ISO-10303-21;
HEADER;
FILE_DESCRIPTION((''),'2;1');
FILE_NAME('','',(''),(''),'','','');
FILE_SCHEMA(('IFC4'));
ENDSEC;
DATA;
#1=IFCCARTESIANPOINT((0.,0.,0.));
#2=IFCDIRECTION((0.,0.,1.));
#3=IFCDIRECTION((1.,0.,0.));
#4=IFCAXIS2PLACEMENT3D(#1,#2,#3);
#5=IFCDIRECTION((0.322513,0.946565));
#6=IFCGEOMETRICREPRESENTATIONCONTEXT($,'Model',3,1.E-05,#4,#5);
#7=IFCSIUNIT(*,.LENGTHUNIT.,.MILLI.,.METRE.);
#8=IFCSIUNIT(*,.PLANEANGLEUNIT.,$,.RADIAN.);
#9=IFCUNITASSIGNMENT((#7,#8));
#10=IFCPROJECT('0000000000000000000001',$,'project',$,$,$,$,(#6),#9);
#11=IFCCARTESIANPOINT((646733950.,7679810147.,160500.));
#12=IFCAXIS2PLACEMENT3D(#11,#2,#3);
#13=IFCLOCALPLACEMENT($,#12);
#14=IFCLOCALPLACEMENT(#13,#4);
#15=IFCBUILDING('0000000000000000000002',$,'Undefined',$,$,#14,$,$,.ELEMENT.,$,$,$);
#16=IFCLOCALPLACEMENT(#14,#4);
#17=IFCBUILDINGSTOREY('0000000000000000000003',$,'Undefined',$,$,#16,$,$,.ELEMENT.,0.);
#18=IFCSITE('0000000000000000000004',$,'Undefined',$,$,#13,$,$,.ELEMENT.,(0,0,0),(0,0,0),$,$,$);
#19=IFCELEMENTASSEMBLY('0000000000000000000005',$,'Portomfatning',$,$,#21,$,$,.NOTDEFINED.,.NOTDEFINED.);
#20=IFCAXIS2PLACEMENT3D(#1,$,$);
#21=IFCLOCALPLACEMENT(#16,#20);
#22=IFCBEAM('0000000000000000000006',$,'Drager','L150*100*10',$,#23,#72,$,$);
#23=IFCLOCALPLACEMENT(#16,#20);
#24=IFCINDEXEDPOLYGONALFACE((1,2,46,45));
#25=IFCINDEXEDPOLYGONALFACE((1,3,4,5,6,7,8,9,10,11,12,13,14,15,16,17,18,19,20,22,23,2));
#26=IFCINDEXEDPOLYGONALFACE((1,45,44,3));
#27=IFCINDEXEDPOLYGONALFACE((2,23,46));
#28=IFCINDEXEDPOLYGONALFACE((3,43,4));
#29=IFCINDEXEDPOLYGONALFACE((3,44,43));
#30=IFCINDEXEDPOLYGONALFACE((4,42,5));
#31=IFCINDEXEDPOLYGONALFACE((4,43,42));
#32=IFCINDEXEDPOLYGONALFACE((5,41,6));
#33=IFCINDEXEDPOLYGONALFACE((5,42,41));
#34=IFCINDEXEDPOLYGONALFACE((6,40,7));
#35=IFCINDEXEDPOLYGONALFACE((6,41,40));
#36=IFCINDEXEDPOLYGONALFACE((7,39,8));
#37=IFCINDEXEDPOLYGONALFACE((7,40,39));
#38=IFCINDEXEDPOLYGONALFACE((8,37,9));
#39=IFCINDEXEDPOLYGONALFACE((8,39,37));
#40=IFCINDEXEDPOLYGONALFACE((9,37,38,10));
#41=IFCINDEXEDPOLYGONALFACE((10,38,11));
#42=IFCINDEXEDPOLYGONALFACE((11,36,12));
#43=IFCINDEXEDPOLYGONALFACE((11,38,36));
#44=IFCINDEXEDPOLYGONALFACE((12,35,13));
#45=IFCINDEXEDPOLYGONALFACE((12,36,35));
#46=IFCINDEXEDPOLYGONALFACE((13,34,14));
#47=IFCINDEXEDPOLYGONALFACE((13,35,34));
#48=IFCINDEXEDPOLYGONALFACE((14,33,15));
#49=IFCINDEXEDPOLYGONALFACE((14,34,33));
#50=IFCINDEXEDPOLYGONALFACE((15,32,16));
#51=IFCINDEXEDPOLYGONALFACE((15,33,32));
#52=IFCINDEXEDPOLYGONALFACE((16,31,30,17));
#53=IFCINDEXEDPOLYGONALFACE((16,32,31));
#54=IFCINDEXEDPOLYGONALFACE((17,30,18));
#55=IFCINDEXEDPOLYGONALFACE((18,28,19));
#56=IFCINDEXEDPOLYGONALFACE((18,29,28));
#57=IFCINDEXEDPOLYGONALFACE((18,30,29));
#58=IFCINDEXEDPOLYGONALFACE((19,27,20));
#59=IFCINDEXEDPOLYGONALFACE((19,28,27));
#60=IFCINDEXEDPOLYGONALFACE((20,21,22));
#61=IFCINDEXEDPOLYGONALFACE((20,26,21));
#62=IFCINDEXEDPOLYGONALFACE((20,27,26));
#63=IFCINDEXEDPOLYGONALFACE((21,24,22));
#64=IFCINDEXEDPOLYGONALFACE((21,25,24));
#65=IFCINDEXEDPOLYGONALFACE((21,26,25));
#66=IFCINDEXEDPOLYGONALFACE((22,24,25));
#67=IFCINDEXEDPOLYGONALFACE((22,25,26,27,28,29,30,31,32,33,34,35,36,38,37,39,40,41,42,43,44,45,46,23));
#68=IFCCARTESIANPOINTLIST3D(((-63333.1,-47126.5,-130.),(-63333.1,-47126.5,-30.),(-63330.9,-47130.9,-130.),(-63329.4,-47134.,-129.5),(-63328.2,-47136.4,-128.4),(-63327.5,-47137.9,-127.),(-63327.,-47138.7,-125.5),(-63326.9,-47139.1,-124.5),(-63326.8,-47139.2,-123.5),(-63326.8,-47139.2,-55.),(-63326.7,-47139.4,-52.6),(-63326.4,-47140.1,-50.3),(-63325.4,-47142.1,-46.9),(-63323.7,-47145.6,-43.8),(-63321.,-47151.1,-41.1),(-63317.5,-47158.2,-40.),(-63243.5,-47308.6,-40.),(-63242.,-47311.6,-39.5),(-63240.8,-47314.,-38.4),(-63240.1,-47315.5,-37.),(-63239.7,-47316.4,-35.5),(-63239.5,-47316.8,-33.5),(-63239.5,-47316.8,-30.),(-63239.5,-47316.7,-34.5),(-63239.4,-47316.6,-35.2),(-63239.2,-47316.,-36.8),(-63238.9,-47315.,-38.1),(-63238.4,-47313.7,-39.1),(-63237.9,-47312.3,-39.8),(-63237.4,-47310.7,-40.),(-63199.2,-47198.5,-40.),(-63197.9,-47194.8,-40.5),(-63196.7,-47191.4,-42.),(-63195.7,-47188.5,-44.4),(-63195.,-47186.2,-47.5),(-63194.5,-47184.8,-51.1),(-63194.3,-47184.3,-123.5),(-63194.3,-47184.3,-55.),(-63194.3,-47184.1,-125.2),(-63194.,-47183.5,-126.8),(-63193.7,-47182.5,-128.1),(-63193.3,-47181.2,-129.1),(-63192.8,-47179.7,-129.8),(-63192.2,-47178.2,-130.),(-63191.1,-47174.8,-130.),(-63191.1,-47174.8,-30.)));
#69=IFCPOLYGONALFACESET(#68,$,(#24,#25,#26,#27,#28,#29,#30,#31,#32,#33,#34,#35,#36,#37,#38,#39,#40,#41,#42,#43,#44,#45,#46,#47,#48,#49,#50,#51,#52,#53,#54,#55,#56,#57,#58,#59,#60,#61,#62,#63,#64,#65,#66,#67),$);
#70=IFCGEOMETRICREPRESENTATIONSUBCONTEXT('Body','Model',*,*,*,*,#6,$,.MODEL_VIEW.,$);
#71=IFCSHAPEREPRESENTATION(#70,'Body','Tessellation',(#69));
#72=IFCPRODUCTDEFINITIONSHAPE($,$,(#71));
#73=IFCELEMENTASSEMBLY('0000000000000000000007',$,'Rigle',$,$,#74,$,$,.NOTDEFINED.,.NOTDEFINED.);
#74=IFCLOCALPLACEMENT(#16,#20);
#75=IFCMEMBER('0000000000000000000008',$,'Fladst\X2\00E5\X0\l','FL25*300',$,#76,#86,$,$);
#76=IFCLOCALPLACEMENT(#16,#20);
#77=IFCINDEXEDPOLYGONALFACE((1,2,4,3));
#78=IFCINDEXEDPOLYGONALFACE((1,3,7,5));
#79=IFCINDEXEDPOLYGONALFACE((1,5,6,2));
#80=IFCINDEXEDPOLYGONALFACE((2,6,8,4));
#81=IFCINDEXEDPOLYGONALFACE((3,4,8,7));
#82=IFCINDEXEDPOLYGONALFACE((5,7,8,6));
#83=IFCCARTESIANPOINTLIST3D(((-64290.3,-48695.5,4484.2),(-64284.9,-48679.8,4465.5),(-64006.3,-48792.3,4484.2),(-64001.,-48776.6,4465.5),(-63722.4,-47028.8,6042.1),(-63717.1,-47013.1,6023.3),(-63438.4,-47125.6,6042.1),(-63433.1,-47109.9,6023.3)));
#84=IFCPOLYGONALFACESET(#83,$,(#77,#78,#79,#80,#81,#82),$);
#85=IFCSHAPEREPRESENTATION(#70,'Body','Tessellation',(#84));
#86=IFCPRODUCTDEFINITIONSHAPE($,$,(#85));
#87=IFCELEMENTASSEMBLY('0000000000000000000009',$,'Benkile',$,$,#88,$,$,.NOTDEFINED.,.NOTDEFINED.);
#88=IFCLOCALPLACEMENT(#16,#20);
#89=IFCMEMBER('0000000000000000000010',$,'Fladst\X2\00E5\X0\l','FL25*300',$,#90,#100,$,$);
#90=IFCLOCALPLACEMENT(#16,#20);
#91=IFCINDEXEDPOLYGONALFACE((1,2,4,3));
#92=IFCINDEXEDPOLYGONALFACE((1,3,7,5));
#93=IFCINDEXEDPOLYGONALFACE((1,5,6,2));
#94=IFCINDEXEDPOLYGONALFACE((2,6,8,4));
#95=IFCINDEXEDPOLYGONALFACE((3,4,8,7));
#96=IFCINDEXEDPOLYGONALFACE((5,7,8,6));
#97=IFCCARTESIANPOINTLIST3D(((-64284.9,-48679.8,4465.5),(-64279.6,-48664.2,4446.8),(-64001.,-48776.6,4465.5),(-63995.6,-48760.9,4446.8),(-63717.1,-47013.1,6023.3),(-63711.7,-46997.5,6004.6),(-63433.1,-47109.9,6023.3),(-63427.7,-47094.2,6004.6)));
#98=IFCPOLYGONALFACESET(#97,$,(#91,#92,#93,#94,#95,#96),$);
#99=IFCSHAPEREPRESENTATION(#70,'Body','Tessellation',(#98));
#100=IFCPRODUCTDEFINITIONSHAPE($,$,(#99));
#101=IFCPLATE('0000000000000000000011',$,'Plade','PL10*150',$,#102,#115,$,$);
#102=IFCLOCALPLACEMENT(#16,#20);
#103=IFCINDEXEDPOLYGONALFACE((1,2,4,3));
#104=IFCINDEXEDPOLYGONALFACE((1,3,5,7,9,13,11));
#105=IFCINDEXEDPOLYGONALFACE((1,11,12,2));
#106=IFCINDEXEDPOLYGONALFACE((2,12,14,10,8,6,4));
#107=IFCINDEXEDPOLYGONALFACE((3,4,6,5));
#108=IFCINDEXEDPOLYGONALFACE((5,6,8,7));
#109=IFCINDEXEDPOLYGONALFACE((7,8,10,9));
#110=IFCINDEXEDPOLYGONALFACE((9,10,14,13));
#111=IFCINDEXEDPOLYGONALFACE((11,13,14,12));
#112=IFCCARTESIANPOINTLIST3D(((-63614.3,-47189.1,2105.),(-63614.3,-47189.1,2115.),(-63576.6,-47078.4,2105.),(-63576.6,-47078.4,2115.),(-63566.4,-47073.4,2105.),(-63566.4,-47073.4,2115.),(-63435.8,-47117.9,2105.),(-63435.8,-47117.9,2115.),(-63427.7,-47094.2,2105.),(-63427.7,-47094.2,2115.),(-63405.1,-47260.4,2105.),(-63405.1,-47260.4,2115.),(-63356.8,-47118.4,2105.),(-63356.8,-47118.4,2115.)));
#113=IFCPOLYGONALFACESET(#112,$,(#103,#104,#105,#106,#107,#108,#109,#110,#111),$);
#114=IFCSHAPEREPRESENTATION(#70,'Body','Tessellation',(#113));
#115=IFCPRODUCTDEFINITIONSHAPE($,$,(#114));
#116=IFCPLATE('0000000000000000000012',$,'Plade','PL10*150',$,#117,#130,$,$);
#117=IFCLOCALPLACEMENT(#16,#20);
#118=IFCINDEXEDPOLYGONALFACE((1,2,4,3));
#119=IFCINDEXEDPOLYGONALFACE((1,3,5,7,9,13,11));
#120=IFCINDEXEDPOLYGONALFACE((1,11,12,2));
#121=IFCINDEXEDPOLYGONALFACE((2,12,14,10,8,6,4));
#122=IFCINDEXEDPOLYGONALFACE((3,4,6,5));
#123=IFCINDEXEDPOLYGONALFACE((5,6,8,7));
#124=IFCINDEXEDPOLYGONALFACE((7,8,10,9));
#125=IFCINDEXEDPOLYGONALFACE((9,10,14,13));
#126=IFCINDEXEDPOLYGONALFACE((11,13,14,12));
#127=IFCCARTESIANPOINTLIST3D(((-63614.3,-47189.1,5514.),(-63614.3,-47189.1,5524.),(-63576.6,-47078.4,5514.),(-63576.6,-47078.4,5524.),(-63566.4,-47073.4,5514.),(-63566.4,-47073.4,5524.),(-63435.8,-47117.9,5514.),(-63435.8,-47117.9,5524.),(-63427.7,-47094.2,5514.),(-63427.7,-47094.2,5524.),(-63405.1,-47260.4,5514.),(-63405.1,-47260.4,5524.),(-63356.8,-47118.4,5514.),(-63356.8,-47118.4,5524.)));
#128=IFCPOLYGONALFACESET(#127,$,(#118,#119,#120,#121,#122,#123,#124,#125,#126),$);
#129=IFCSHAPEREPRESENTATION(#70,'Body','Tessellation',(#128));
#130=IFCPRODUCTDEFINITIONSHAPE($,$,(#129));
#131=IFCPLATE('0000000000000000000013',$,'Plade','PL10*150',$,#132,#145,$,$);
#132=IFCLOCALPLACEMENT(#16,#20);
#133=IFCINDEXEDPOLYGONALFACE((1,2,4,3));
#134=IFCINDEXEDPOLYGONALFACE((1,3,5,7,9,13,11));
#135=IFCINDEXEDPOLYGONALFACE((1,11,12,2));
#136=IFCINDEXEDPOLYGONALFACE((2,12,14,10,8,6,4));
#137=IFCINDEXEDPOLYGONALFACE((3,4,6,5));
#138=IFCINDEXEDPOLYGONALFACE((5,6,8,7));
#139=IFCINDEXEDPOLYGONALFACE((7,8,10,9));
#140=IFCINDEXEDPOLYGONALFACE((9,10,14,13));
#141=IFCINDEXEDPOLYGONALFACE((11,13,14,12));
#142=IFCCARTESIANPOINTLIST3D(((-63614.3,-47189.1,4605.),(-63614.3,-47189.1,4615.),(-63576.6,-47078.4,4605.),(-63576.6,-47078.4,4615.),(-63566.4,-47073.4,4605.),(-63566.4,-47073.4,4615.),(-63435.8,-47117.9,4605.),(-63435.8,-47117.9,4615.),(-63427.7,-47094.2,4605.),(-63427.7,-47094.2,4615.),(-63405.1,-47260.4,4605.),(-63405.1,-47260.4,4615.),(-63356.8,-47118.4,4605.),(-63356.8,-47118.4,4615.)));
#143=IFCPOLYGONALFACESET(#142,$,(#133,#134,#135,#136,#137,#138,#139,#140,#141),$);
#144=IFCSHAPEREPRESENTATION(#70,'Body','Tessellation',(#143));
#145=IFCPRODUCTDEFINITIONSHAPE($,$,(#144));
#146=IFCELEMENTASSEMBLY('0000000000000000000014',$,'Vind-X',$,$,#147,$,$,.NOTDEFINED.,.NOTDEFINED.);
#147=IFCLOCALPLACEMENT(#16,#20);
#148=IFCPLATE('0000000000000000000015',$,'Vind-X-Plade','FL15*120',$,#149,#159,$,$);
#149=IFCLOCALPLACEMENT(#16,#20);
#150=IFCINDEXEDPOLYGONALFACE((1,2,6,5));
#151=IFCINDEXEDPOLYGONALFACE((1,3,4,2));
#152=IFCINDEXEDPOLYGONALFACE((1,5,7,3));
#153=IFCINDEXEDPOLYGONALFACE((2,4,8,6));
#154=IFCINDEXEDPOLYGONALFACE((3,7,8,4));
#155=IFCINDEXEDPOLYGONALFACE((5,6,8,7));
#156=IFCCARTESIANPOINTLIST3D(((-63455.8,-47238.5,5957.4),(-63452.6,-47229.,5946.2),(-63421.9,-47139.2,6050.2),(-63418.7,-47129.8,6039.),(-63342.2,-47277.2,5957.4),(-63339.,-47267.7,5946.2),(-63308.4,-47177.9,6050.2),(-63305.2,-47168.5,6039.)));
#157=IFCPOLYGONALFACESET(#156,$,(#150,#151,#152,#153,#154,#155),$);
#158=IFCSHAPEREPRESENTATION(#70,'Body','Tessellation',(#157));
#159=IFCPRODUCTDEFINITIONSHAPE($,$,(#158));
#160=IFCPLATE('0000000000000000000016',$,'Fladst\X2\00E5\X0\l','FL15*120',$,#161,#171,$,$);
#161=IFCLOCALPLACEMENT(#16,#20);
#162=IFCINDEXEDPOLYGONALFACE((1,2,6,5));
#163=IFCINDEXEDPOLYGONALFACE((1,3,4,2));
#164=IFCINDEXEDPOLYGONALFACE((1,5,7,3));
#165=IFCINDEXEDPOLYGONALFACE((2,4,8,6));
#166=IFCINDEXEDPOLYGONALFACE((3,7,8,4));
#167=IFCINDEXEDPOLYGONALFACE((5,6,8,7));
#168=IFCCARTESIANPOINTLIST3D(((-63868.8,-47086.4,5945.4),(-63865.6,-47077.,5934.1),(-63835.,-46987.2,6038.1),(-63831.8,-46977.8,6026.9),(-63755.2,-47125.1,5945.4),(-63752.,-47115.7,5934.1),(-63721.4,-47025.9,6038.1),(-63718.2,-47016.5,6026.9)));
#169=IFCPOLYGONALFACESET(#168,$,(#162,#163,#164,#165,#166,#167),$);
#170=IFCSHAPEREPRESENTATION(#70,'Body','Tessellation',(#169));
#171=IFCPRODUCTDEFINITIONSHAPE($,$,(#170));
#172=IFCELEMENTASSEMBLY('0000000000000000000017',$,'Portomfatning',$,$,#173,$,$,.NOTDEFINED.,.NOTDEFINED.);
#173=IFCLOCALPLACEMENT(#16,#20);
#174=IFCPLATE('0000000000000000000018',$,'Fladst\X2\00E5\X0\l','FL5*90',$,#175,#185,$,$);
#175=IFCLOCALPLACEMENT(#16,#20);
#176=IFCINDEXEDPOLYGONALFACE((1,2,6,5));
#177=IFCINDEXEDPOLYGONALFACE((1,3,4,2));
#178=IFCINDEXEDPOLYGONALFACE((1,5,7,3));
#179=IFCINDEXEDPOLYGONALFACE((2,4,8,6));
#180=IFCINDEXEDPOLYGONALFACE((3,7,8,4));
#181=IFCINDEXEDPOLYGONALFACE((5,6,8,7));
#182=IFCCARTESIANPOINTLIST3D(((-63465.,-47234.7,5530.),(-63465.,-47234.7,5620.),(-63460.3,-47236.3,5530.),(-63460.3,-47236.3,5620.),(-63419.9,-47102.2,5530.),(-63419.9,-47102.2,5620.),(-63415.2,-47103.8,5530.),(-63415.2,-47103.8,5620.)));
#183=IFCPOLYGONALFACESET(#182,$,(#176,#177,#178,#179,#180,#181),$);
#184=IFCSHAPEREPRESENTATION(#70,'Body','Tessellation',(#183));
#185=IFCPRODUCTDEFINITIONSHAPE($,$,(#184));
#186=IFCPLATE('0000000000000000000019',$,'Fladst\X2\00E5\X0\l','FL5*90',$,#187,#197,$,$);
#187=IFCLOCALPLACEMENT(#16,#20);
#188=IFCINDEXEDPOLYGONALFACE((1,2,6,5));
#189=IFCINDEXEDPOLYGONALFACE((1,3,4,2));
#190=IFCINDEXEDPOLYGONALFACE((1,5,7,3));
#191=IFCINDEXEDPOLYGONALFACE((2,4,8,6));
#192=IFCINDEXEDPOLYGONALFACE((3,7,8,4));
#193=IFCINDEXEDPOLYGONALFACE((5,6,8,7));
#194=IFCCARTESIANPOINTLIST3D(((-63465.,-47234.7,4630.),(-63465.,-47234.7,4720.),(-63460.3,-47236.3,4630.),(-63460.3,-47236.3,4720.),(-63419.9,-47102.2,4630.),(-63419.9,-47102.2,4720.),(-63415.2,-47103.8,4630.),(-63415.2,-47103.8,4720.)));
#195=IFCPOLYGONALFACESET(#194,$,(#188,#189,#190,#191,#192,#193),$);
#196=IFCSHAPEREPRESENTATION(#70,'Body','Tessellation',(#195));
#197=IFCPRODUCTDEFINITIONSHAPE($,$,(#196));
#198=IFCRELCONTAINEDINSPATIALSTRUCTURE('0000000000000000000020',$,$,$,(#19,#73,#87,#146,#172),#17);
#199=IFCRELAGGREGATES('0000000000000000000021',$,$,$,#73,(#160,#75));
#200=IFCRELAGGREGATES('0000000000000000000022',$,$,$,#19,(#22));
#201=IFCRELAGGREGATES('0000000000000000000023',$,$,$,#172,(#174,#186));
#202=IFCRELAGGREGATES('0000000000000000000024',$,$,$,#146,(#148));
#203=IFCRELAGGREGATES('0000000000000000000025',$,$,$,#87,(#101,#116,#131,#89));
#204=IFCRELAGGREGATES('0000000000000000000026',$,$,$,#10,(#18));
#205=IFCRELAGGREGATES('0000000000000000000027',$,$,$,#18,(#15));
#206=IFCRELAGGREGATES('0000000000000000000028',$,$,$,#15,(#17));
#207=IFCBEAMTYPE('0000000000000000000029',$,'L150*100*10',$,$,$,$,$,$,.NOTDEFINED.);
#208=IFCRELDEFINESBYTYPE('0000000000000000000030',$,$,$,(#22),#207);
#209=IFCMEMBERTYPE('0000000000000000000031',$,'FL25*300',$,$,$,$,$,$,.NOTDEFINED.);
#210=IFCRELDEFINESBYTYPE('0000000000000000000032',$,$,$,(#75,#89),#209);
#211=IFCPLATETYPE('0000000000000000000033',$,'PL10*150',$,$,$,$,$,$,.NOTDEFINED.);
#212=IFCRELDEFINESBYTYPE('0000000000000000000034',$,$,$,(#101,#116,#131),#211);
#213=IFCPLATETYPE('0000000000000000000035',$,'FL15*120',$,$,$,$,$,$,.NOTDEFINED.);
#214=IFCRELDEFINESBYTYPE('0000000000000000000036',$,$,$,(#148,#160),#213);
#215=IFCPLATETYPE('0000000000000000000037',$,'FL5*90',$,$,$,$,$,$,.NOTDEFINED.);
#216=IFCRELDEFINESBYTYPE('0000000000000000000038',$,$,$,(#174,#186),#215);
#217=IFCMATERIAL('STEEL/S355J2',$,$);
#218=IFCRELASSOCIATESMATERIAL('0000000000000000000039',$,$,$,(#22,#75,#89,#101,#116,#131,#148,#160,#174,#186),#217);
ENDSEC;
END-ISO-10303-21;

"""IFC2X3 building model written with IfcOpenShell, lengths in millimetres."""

from ifc_helpers import new_model, si_unit, direction, frame, origin_with_axes, origin_2d_with_axis, place, context, subcontext, project, spatial, polyline, rectangle, l_section, outline, extrude, boolean, clip, halfspace, material, type_object, element, aggregate, save


model = new_model("IFC2X3")

# Units and contexts
model_context = context("Model", 3, precision=1e-05, world=origin_with_axes(), true_north=direction((0.322513, 0.946565)))
body_context = subcontext(model_context, "Body", "Model", "MODEL_VIEW")
ifc_project = project(units=[si_unit("LENGTHUNIT", "METRE", prefix="MILLI"), si_unit("PLANEANGLEUNIT", "RADIAN")], contexts=[model_context])

# Site, building, storey
site_placement = place(None, frame((646733950.0, 7679810147.0, 160500.0), z_axis=(0.0, 0.0, 1.0), x_axis=(1.0, 0.0, 0.0)))
site = spatial("IfcSite", under=ifc_project, at=site_placement, Name="Undefined", CompositionType="ELEMENT", RefLatitude=(0, 0, 0), RefLongitude=(0, 0, 0))
building_placement = place(site_placement, origin_with_axes())
building = spatial("IfcBuilding", under=site, at=building_placement, Name="Undefined", CompositionType="ELEMENT")
storey_placement = place(building_placement, origin_with_axes())
storey = spatial("IfcBuildingStorey", under=building, at=storey_placement, Name="Undefined", CompositionType="ELEMENT", Elevation=0.0)

# Element assembly, beam
assembly_1_placement = place(storey_placement, origin_with_axes())
assembly_1 = element("IfcElementAssembly", 1, at=assembly_1_placement, inside=storey, Name="Portomfatning", AssemblyPlace="NOTDEFINED", PredefinedType="NOTDEFINED")
ifc_material_1 = material(Name="STEEL/S355J2")
beam_type = type_object("IfcBeamType", Name="L150*100*10", PredefinedType="NOTDEFINED")
beam_placement = place(assembly_1_placement, frame((-63357.3, -47197.5, -80.0), z_axis=(-0.322513, -0.946565, 0.0), x_axis=(0.946565, -0.322513, 0.0)))
beam = element("IfcBeam", 2, at=beam_placement, type_object=beam_type, material=ifc_material_1, Name="Drager", Description="L150*100*10", context=body_context, shape_type="Clipping", body=[
    clip(extrude(l_section(Depth=150.0, Width=100.0, Thickness=10.0, FilletRadius=15.0, EdgeRadius=6.5, at=origin_2d_with_axis()), frame((150.0, 0.0, 0.0), z_axis=(-1.0, 0.0, 0.0), x_axis=(0.0, -1.0, 0.0)), (0.0, 0.0, 1.0), 150.0), halfspace(frame((0.0, -50.0, -75.0), z_axis=(-0.707105, 0.0, 0.707109), x_axis=(0.0, 1.0, 0.0)), False)),
])

# Element assembly, member
assembly_2_placement = place(storey_placement, origin_with_axes())
assembly_2 = element("IfcElementAssembly", 3, at=assembly_2_placement, inside=storey, Name="Rigle", AssemblyPlace="NOTDEFINED", PredefinedType="NOTDEFINED")
member_type = type_object("IfcMemberType", Name="FL25*300", PredefinedType="NOTDEFINED")
member_1_placement = place(assembly_2_placement, frame((-63577.7, -47069.4, 6032.7), z_axis=(-0.946565, 0.322513, 0.0), x_axis=(-0.241548, -0.708935, -0.66262)))
member_1 = element("IfcMember", 4, at=member_1_placement, type_object=member_type, material=ifc_material_1, Name="Fladstål", Description="FL25*300", context=body_context, shape_type="SweptSolid", body=[
    extrude(rectangle(XDim=25.0, YDim=300.0, at=origin_2d_with_axis()), frame((2351.0, 0.0, 0.0), z_axis=(-1.0, 0.0, 0.0), x_axis=(0.0, -1.0, 0.0)), (0.0, 0.0, 1.0), 2351.0),
])

# Element assembly, member, plates
assembly_3_placement = place(storey_placement, origin_with_axes())
assembly_3 = element("IfcElementAssembly", 5, at=assembly_3_placement, inside=storey, Name="Benkile", AssemblyPlace="NOTDEFINED", PredefinedType="NOTDEFINED")
member_2_placement = place(assembly_3_placement, frame((-63572.4, -47053.7, 6014.0), z_axis=(-0.946565, 0.322513, 0.0), x_axis=(-0.241548, -0.708935, -0.66262)))
member_2 = element("IfcMember", 6, at=member_2_placement, type_object=member_type, material=ifc_material_1, Name="Fladstål", Description="FL25*300", context=body_context, shape_type="SweptSolid", body=[
    extrude(rectangle(XDim=25.0, YDim=300.0, at=origin_2d_with_axis()), frame((2351.0, 0.0, 0.0), z_axis=(-1.0, 0.0, 0.0), x_axis=(0.0, -1.0, 0.0)), (0.0, 0.0, 1.0), 2351.0),
])
plate_type_1 = type_object("IfcPlateType", Name="PL10*150", PredefinedType="NOTDEFINED")
plate_1_placement = place(assembly_3_placement, frame((-63565.9, -47047.1, 2110.0), z_axis=(0.0, 0.0, -1.0), x_axis=(0.946565, -0.322513, 0.0)))
plate_1 = element("IfcPlate", 7, at=plate_1_placement, type_object=plate_type_1, material=ifc_material_1, Name="Plade", Description="PL10*150", context=body_context, shape_type="CSG", body=[
    boolean("DIFFERENCE", extrude(outline(polyline([(0.0, 25.0), (146.0, 25.0), (146.0, 0.0), (221.0, 0.0), (221.0, 150.0), (0.0, 150.0), (0.0, 25.0)])), frame((0.0, 0.0, -5.0), z_axis=(0.0, 0.0, 1.0), x_axis=(1.0, 0.0, 0.0)), (0.0, 0.0, 1.0), 10.0), extrude(outline(polyline([(0.0, 0.0), (8.0, 0.0), (0.0, 8.0), (0.0, 0.0)])), frame((0.0, 25.0, -7.5), z_axis=(0.0, 0.0, 1.0), x_axis=(1.0, 0.0, 0.0)), (0.0, 0.0, 1.0), 15.0)),
])
plate_2_placement = place(assembly_3_placement, frame((-63565.9, -47047.1, 5519.0), z_axis=(0.0, 0.0, -1.0), x_axis=(0.946565, -0.322513, 0.0)))
plate_2 = element("IfcPlate", 8, at=plate_2_placement, type_object=plate_type_1, material=ifc_material_1, Name="Plade", Description="PL10*150", context=body_context, shape_type="CSG", body=[
    boolean("DIFFERENCE", extrude(outline(polyline([(0.0, 25.0), (146.0, 25.0), (146.0, 0.0), (221.0, 0.0), (221.0, 150.0), (0.0, 150.0), (0.0, 25.0)])), frame((0.0, 0.0, -5.0), z_axis=(0.0, 0.0, 1.0), x_axis=(1.0, 0.0, 0.0)), (0.0, 0.0, 1.0), 10.0), extrude(outline(polyline([(0.0, 0.0), (8.0, 0.0), (0.0, 8.0), (0.0, 0.0)])), frame((0.0, 25.0, -7.5), z_axis=(0.0, 0.0, 1.0), x_axis=(1.0, 0.0, 0.0)), (0.0, 0.0, 1.0), 15.0)),
])
plate_3_placement = place(assembly_3_placement, frame((-63565.9, -47047.1, 4610.0), z_axis=(0.0, 0.0, -1.0), x_axis=(0.946565, -0.322513, 0.0)))
plate_3 = element("IfcPlate", 9, at=plate_3_placement, type_object=plate_type_1, material=ifc_material_1, Name="Plade", Description="PL10*150", context=body_context, shape_type="CSG", body=[
    boolean("DIFFERENCE", extrude(outline(polyline([(0.0, 25.0), (146.0, 25.0), (146.0, 0.0), (221.0, 0.0), (221.0, 150.0), (0.0, 150.0), (0.0, 25.0)])), frame((0.0, 0.0, -5.0), z_axis=(0.0, 0.0, 1.0), x_axis=(1.0, 0.0, 0.0)), (0.0, 0.0, 1.0), 10.0), extrude(outline(polyline([(0.0, 0.0), (8.0, 0.0), (0.0, 8.0), (0.0, 0.0)])), frame((0.0, 25.0, -7.5), z_axis=(0.0, 0.0, 1.0), x_axis=(1.0, 0.0, 0.0)), (0.0, 0.0, 1.0), 15.0)),
])

# Element assembly, plate
assembly_4_placement = place(storey_placement, origin_with_axes())
assembly_4 = element("IfcElementAssembly", 10, at=assembly_4_placement, inside=storey, Name="Vind-X", AssemblyPlace="NOTDEFINED", PredefinedType="NOTDEFINED")
plate_type_2 = type_object("IfcPlateType", Name="FL15*120", PredefinedType="NOTDEFINED")
plate_4_placement = place(assembly_4_placement, frame((-63437.3, -47184.1, 5998.2), z_axis=(-0.213703, -0.627213, 0.748956), x_axis=(0.946565, -0.322513, 0.0)))
plate_4 = element("IfcPlate", 11, at=plate_4_placement, type_object=plate_type_2, material=ifc_material_1, Name="Vind-X-Plade", Description="FL15*120", context=body_context, shape_type="SweptSolid", body=[
    extrude(outline(polyline([(0.0, -70.0), (0.0, 70.0), (120.0, 70.0), (120.0, -70.0), (0.0, -70.0)])), frame((0.0, 0.0, -7.5), z_axis=(0.0, 0.0, 1.0), x_axis=(1.0, 0.0, 0.0)), (0.0, 0.0, 1.0), 15.0),
])

# Plate
plate_5_placement = place(assembly_2_placement, frame((-63753.6, -47120.4, 5939.7), z_axis=(-0.213703, -0.627213, 0.748956), x_axis=(0.241548, 0.708935, 0.66262)))
plate_5 = element("IfcPlate", 12, at=plate_5_placement, type_object=plate_type_2, material=ifc_material_1, Name="Fladstål", Description="FL15*120", context=body_context, shape_type="SweptSolid", body=[
    extrude(outline(polyline([(0.0, 0.0), (140.0, 0.0), (140.0, 120.0), (0.0, 120.0), (0.0, 0.0)])), frame((0.0, 0.0, -7.5), z_axis=(0.0, 0.0, 1.0), x_axis=(1.0, 0.0, 0.0)), (0.0, 0.0, 1.0), 15.0),
])

# Element assembly, plates
assembly_5_placement = place(storey_placement, origin_with_axes())
assembly_5 = element("IfcElementAssembly", 13, at=assembly_5_placement, inside=storey, Name="Portomfatning", AssemblyPlace="NOTDEFINED", PredefinedType="NOTDEFINED")
plate_type_3 = type_object("IfcPlateType", Name="FL5*90", PredefinedType="NOTDEFINED")
plate_6_placement = place(assembly_5_placement, frame((-63417.6, -47103.0, 5530.0), z_axis=(0.946638, -0.322299, 0.0), x_axis=(0.0, 0.0, 1.0)))
plate_6 = element("IfcPlate", 14, at=plate_6_placement, type_object=plate_type_3, material=ifc_material_1, Name="Fladstål", Description="FL5*90", context=body_context, shape_type="SweptSolid", body=[
    extrude(outline(polyline([(0.0, 0.0), (90.0, 0.0), (90.0, 140.0), (0.0, 140.0), (0.0, 0.0)])), frame((0.0, 0.0, -2.5), z_axis=(0.0, 0.0, 1.0), x_axis=(1.0, 0.0, 0.0)), (0.0, 0.0, 1.0), 5.0),
])
plate_7_placement = place(assembly_5_placement, frame((-63417.6, -47103.0, 4630.0), z_axis=(0.946638, -0.322299, 0.0), x_axis=(0.0, 0.0, 1.0)))
plate_7 = element("IfcPlate", 15, at=plate_7_placement, type_object=plate_type_3, material=ifc_material_1, Name="Fladstål", Description="FL5*90", context=body_context, shape_type="SweptSolid", body=[
    extrude(outline(polyline([(0.0, 0.0), (90.0, 0.0), (90.0, 140.0), (0.0, 140.0), (0.0, 0.0)])), frame((0.0, 0.0, -2.5), z_axis=(0.0, 0.0, 1.0), x_axis=(1.0, 0.0, 0.0)), (0.0, 0.0, 1.0), 5.0),
])

aggregate(assembly_2, [plate_5, member_1])

aggregate(assembly_1, [beam])
aggregate(assembly_5, [plate_6, plate_7])
aggregate(assembly_4, [plate_4])

aggregate(assembly_3, [plate_1, plate_2, plate_3, member_2])

save(model, "model.ifc")
